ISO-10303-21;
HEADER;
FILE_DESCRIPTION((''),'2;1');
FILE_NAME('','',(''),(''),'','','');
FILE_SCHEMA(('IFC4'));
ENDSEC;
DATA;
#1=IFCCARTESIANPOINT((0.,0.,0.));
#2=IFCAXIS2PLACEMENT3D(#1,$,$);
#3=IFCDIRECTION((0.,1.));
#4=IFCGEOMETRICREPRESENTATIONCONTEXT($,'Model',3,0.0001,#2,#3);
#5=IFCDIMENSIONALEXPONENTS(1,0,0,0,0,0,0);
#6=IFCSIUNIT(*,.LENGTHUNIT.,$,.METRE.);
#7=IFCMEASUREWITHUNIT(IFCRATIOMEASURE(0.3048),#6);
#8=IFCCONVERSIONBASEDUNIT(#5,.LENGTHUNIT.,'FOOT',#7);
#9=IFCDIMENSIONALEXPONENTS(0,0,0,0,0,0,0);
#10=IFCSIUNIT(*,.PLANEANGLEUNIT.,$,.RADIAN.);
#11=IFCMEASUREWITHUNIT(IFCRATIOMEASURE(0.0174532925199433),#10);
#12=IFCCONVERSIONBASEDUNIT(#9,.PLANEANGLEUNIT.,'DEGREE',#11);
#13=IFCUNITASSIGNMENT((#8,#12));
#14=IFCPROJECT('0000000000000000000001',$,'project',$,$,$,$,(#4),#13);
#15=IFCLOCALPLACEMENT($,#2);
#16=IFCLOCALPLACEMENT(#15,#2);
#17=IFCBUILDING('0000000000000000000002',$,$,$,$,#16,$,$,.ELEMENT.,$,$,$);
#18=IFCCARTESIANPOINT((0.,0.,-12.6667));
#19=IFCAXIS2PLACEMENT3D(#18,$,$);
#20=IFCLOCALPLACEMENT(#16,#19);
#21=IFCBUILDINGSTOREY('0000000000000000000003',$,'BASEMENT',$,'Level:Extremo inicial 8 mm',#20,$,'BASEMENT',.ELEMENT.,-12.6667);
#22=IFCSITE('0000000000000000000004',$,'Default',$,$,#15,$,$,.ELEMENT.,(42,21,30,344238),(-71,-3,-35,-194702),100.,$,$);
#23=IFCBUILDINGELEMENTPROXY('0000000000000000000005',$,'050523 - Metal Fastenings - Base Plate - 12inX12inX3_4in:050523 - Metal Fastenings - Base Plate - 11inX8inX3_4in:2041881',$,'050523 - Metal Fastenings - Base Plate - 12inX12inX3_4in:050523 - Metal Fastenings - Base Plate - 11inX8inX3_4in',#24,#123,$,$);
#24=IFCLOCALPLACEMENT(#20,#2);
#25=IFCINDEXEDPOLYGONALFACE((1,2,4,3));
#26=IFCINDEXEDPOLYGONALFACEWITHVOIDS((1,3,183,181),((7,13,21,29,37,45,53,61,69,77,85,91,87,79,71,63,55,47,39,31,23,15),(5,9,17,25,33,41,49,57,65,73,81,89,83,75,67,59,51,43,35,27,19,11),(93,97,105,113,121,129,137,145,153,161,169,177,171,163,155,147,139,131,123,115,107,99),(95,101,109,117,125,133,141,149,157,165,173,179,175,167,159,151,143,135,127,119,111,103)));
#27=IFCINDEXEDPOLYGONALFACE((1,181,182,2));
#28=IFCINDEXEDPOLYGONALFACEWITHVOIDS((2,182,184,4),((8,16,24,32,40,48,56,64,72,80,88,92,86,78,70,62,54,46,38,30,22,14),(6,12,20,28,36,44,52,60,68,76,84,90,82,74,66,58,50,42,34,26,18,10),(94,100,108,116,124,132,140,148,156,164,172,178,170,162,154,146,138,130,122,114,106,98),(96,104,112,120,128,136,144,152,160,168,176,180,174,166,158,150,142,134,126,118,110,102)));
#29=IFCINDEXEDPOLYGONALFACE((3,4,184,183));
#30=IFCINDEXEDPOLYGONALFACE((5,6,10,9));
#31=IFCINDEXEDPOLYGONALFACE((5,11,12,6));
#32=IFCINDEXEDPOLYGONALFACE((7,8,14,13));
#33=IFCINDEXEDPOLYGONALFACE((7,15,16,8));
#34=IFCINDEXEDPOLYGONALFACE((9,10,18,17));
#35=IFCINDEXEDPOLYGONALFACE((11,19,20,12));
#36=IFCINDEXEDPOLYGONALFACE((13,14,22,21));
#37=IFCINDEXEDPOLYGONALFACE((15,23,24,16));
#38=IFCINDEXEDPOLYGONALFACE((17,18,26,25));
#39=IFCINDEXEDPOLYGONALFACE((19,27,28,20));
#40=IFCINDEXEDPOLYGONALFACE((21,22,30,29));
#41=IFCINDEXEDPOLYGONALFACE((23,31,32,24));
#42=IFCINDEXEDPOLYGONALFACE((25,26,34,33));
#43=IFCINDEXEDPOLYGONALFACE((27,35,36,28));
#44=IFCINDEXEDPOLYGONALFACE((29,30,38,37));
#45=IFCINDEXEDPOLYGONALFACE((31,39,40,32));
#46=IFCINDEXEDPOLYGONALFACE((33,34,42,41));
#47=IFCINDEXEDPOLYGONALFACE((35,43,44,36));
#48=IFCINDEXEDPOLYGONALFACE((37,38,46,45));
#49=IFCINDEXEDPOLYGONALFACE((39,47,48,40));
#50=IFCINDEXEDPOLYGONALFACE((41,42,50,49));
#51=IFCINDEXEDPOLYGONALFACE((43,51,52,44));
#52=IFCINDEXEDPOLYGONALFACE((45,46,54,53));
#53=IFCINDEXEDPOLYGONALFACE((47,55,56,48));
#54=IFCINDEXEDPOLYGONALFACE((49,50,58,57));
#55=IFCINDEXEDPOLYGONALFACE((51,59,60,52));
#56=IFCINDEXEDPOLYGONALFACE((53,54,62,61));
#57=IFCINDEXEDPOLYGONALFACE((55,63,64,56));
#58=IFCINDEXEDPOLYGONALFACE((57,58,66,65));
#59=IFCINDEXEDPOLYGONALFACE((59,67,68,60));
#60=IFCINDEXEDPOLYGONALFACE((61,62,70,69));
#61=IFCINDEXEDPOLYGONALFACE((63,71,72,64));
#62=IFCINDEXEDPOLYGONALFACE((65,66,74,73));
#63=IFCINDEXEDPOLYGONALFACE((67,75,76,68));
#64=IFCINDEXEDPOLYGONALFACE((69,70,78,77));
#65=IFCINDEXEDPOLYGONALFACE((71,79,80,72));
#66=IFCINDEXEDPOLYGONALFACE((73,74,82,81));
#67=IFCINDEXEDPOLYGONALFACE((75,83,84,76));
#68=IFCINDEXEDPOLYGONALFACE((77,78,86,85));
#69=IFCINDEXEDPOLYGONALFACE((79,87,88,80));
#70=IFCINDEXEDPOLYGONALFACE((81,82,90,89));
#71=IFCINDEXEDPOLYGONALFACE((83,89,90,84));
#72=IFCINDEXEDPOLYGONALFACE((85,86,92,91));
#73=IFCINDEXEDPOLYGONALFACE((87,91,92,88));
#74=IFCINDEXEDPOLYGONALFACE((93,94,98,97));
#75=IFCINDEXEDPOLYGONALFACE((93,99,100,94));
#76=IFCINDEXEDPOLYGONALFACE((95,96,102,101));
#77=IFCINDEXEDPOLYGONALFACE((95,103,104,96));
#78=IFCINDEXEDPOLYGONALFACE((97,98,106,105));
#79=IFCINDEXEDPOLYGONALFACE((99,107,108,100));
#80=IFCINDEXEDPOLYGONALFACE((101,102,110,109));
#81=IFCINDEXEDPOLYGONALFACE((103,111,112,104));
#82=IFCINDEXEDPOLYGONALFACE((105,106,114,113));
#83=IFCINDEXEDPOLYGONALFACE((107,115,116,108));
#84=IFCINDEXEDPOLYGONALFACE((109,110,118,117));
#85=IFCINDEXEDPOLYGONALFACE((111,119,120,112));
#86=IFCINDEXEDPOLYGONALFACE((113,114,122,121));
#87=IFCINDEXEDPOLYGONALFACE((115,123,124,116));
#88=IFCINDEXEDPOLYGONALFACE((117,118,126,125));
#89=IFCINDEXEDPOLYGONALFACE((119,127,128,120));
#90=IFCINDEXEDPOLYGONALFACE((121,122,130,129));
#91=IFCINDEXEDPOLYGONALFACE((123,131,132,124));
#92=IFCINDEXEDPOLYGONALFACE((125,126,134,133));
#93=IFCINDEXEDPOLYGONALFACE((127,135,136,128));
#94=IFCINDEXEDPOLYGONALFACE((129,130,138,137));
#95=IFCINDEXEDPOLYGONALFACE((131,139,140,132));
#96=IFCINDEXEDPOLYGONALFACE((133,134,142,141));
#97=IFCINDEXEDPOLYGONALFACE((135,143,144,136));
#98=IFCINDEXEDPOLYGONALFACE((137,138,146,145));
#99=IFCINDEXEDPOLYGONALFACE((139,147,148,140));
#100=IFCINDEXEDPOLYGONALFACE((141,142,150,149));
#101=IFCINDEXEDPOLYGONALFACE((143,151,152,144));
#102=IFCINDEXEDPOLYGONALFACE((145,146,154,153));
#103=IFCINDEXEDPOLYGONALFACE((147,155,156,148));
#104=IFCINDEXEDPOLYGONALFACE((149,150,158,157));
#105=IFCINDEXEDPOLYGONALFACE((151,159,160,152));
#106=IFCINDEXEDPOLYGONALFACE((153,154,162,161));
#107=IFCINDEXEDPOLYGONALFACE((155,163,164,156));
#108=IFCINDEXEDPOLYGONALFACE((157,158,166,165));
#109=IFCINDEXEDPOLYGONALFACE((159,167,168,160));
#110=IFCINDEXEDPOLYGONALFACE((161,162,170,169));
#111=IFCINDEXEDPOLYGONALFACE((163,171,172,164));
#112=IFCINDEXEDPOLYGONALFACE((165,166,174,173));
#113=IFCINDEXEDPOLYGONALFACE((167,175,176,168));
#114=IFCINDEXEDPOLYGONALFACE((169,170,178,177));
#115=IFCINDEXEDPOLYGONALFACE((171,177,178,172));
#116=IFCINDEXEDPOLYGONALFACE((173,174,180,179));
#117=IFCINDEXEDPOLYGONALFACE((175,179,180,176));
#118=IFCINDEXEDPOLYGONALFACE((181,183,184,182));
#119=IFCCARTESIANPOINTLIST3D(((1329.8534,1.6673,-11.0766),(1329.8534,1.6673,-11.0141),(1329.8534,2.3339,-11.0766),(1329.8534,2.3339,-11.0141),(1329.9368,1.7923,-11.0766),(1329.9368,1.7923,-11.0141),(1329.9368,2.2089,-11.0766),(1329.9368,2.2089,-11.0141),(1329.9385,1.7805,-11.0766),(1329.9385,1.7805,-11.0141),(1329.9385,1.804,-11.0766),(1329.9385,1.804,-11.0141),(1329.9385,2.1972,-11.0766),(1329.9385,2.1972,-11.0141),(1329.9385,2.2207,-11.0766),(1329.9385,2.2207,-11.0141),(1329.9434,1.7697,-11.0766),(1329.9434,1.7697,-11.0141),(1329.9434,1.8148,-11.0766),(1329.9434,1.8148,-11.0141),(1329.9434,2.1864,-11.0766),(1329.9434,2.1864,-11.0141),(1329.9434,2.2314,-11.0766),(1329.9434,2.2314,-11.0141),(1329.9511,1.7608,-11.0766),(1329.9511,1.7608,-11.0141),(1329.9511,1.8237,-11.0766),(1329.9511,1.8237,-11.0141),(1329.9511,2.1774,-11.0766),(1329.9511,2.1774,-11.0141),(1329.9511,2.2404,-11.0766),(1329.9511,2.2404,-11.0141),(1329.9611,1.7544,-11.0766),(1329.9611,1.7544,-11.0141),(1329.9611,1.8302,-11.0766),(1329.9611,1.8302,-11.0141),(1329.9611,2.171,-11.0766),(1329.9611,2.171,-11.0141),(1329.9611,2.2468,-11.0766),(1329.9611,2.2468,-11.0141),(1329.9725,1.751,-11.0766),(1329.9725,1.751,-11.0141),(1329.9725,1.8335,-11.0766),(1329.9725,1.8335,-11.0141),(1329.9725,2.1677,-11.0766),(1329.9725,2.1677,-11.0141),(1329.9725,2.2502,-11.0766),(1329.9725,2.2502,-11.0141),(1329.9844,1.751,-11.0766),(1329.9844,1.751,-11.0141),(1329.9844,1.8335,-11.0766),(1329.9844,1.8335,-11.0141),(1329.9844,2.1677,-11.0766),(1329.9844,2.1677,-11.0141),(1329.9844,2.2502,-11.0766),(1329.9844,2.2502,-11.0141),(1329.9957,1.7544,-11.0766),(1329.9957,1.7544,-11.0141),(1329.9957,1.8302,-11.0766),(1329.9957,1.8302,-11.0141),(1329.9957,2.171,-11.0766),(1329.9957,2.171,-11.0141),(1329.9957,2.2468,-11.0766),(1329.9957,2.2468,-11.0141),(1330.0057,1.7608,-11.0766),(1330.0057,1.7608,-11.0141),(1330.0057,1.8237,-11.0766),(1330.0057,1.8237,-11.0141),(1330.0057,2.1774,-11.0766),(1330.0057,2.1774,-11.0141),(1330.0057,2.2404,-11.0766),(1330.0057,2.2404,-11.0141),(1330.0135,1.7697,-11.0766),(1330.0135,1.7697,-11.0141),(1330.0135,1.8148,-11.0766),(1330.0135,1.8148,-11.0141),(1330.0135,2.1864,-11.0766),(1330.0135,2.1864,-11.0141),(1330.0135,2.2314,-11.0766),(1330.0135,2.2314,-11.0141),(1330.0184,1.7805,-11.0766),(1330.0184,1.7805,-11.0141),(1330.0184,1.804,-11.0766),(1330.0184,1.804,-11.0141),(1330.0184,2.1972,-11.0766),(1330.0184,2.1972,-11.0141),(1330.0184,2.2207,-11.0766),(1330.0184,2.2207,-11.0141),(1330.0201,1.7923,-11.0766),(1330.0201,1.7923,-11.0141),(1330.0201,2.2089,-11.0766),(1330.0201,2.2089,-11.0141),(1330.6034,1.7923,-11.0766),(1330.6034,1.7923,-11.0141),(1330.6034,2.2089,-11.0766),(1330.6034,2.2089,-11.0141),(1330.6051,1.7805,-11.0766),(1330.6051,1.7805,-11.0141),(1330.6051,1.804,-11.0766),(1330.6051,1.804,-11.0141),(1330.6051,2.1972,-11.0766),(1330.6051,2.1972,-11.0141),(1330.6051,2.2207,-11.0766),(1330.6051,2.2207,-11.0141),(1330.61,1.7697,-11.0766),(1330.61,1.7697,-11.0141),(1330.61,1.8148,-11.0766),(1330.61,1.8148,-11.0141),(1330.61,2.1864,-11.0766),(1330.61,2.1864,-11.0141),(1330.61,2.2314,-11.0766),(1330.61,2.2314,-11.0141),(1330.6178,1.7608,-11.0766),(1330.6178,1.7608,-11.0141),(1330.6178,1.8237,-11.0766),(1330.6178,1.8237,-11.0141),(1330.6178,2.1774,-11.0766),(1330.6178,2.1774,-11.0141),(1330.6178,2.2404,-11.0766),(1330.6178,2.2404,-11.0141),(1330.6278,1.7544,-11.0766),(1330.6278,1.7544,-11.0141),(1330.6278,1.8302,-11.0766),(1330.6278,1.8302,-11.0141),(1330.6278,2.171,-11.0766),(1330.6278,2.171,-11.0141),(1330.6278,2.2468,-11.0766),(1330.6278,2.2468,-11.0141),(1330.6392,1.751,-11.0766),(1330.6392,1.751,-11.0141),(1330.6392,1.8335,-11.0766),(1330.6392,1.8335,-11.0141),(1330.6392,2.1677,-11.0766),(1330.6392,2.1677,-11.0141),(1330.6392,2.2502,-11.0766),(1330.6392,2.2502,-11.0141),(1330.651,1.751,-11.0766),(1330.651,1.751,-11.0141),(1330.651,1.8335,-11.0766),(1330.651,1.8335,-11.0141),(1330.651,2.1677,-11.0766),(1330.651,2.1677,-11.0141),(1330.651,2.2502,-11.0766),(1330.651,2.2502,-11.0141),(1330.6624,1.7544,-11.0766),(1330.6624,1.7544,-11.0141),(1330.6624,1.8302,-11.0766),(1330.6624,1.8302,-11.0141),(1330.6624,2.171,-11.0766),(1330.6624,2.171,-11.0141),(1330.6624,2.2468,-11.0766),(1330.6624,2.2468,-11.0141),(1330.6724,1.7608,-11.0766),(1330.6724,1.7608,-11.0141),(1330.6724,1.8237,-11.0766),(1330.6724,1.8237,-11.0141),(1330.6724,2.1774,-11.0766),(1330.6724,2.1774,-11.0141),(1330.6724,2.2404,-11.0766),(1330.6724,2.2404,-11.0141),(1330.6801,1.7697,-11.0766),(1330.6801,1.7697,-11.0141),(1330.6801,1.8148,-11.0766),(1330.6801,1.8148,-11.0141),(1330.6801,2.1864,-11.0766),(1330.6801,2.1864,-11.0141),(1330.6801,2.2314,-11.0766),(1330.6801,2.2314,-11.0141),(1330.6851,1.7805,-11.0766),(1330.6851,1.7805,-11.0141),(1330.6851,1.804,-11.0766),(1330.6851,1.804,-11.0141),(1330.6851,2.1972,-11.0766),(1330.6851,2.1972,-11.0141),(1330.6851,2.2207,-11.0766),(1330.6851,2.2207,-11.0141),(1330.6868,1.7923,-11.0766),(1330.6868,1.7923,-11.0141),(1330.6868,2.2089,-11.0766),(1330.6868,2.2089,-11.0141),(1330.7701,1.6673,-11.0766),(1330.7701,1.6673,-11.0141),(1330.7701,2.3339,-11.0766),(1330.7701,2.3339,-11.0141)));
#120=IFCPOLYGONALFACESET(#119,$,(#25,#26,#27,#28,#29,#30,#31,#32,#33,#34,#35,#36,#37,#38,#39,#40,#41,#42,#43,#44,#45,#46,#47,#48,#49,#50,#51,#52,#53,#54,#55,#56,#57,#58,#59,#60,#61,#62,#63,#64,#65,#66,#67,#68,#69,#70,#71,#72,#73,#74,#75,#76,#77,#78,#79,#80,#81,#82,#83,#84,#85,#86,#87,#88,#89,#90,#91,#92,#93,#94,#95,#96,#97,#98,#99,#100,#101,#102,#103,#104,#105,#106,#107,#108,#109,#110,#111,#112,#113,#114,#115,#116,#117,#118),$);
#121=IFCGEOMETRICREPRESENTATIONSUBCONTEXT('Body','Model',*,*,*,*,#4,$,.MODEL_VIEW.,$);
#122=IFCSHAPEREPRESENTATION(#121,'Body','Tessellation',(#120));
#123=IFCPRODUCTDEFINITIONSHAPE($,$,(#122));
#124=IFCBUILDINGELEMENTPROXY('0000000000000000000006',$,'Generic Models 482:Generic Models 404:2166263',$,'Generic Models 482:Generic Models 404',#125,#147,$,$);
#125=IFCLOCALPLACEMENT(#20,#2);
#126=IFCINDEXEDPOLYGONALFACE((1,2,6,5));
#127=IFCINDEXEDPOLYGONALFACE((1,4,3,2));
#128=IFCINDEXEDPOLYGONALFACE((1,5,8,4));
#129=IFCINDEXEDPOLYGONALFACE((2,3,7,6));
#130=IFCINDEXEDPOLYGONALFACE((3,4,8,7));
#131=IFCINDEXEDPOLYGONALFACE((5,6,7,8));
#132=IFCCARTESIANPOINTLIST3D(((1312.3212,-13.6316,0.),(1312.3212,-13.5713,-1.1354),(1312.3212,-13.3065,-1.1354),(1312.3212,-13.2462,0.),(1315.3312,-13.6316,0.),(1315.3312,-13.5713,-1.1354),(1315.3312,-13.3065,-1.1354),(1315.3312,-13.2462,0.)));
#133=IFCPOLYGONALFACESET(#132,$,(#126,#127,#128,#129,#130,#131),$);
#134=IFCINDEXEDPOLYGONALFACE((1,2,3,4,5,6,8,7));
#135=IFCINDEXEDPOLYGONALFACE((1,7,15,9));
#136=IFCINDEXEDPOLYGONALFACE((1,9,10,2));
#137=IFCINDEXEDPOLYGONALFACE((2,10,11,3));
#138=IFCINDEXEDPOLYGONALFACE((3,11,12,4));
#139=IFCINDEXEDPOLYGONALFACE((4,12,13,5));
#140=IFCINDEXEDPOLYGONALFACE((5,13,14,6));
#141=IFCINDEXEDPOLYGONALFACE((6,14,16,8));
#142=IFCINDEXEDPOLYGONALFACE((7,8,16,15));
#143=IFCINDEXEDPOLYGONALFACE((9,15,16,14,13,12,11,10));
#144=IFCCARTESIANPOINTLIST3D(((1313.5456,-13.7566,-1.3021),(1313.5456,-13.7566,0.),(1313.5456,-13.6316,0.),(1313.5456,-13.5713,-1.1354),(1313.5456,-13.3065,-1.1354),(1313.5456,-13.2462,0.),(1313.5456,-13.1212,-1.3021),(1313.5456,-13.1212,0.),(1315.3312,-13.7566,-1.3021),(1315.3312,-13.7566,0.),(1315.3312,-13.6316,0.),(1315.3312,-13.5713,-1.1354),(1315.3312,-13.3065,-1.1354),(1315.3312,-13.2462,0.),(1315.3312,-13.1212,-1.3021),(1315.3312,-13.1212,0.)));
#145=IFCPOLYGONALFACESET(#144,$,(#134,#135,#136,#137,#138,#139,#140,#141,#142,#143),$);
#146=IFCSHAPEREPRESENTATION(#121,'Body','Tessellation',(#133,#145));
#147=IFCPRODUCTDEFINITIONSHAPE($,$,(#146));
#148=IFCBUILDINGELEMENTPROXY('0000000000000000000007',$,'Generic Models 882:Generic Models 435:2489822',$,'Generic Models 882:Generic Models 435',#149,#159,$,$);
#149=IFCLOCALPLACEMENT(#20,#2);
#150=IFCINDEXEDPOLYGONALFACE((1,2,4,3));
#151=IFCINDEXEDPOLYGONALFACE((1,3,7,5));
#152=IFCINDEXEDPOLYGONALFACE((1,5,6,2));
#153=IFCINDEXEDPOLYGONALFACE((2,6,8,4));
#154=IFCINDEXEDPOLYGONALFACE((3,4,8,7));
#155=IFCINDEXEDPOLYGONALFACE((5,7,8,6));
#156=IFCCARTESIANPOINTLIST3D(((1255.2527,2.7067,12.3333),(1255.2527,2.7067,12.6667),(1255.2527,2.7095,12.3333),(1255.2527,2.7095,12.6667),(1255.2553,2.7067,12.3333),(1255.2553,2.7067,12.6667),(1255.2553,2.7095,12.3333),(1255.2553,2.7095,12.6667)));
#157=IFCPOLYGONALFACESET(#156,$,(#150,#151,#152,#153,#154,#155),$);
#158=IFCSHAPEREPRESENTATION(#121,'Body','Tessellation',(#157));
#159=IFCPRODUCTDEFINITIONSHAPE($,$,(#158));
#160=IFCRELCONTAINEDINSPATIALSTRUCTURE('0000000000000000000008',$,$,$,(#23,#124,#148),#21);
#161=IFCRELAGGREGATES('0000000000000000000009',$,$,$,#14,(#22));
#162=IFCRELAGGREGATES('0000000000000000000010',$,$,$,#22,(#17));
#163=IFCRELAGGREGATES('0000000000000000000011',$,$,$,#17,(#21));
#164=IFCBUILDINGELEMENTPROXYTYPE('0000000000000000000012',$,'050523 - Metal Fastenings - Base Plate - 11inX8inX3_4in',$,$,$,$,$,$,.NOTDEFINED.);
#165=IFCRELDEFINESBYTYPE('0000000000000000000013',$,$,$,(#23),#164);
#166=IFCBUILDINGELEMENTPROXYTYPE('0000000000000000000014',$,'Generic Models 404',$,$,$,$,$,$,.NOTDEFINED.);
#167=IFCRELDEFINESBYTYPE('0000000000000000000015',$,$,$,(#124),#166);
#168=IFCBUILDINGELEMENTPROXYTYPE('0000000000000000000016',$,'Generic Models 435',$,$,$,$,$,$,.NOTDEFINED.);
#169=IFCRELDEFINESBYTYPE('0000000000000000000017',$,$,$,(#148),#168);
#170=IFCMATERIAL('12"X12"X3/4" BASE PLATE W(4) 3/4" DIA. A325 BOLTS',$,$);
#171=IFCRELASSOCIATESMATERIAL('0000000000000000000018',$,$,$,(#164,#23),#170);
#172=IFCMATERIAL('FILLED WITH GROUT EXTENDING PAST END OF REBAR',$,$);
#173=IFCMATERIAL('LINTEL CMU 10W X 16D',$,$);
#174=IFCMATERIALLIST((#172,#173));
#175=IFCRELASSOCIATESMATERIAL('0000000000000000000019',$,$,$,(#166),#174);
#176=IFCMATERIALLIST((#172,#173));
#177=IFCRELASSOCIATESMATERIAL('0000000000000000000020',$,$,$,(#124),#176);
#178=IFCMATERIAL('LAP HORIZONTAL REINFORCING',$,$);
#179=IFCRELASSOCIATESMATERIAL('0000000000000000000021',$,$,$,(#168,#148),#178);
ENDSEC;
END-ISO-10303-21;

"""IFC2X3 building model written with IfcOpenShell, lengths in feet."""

from ifc_helpers import new_model, entity, si_unit, converted_unit, direction, frame, frame_2d, origin, place, context, subcontext, project, spatial, polyline, circle_curve, parameter, trimmed, segment, composite_curve, rectangle, outline, extrude, source, transform, mapped, material, material_list, type_object, type_shapes, element, save


model = new_model("IFC2X3")

# Units and contexts
model_context = context("Model", 3, precision=0.0001, world=origin(), true_north=direction((0.0, 1.0)))
body_context = subcontext(model_context, "Body", "Model", "MODEL_VIEW")
ifc_project = project(units=[converted_unit("LENGTHUNIT", "FOOT", entity("IfcRatioMeasure", 0.3048), si_unit("LENGTHUNIT", "METRE"), dimensions=[1, 0, 0, 0, 0, 0, 0]), converted_unit("PLANEANGLEUNIT", "DEGREE", entity("IfcRatioMeasure", 0.0174532925199433), si_unit("PLANEANGLEUNIT", "RADIAN"), dimensions=[0, 0, 0, 0, 0, 0, 0])], contexts=[model_context])

# Site, building, storey
site_placement = place(None, origin())
site = spatial("IfcSite", under=ifc_project, at=site_placement, Name="Default", CompositionType="ELEMENT", RefLatitude=(42, 21, 30, 344238), RefLongitude=(-71, -3, -35, -194702), RefElevation=100.0)
building_placement = place(site_placement, origin())
building = spatial("IfcBuilding", under=site, at=building_placement, CompositionType="ELEMENT")
storey_placement = place(building_placement, frame((0.0, 0.0, -12.6667)))
storey = spatial("IfcBuildingStorey", under=building, at=storey_placement, Name="BASEMENT", ObjectType="Level:Extremo inicial 8 mm", LongName="BASEMENT", CompositionType="ELEMENT", Elevation=-12.6667)

# Building element proxies
ifc_material_1 = material(Name="12\"X12\"X3/4\" BASE PLATE W(4) 3/4\" DIA. A325 BOLTS")
building_element_proxy_type_1 = type_object("IfcBuildingElementProxyType", Name="050523 - Metal Fastenings - Base Plate - 11inX8inX3_4in", PredefinedType="NOTDEFINED", material=ifc_material_1)
shared_shape_1 = source(origin(), body_context, "Body", "SweptSolid", [
    extrude(outline(polyline([(-0.4583, -0.3333), (0.4583, -0.3333), (0.4583, 0.3333), (-0.4583, 0.3333), (-0.4583, -0.3333)]), holes=[composite_curve([segment(trimmed(circle_curve(frame_2d((-0.3333, -0.2083), x_axis=(-1.0, 0.0)), 0.0417), [parameter(180.0)], [parameter(0.0)], True, "PARAMETER"), False, "CONTINUOUS"), segment(trimmed(circle_curve(frame_2d((-0.3333, -0.2083), x_axis=(-1.0, 0.0)), 0.0417), [parameter(0.0)], [parameter(180.0)], True, "PARAMETER"), False, "CONTINUOUS")], self_intersect=False), composite_curve([segment(trimmed(circle_curve(frame_2d((0.3333, -0.2083), x_axis=(-1.0, 0.0)), 0.0417), [parameter(180.0)], [parameter(0.0)], True, "PARAMETER"), False, "CONTINUOUS"), segment(trimmed(circle_curve(frame_2d((0.3333, -0.2083), x_axis=(-1.0, 0.0)), 0.0417), [parameter(0.0)], [parameter(180.0)], True, "PARAMETER"), False, "CONTINUOUS")], self_intersect=False), composite_curve([segment(trimmed(circle_curve(frame_2d((-0.3333, 0.2083), x_axis=(-1.0, 0.0)), 0.0417), [parameter(180.0)], [parameter(0.0)], True, "PARAMETER"), False, "CONTINUOUS"), segment(trimmed(circle_curve(frame_2d((-0.3333, 0.2083), x_axis=(-1.0, 0.0)), 0.0417), [parameter(0.0)], [parameter(180.0)], True, "PARAMETER"), False, "CONTINUOUS")], self_intersect=False), composite_curve([segment(trimmed(circle_curve(frame_2d((0.3333, 0.2083), x_axis=(-1.0, 0.0)), 0.0417), [parameter(180.0)], [parameter(0.0)], True, "PARAMETER"), False, "CONTINUOUS"), segment(trimmed(circle_curve(frame_2d((0.3333, 0.2083), x_axis=(-1.0, 0.0)), 0.0417), [parameter(0.0)], [parameter(180.0)], True, "PARAMETER"), False, "CONTINUOUS")], self_intersect=False)]), frame((0.0, 0.0, 0.0), z_axis=(0.0, 0.0, 1.0), x_axis=(-1.0, 0.0, 0.0)), (0.0, 0.0, 1.0), 0.0625),
])
type_shapes(building_element_proxy_type_1, [shared_shape_1])
proxy_1_placement = place(storey_placement, frame((1330.3118, 2.0006, -11.0766)))
element("IfcBuildingElementProxy", 1, at=proxy_1_placement, inside=storey, type_object=building_element_proxy_type_1, material=ifc_material_1, Name="050523 - Metal Fastenings - Base Plate - 12inX12inX3_4in:050523 - Metal Fastenings - Base Plate - 11inX8inX3_4in:2041881", ObjectType="050523 - Metal Fastenings - Base Plate - 12inX12inX3_4in:050523 - Metal Fastenings - Base Plate - 11inX8inX3_4in", context=body_context, shape_type="MappedRepresentation", body=[
    mapped(shared_shape_1, transform((0.0, 0.0, 0.0), scale=1.0)),
])
ifc_material_2 = material(Name="FILLED WITH GROUT EXTENDING PAST END OF REBAR")
ifc_material_3 = material(Name="LINTEL CMU 10W X 16D")
ifc_material_list_1 = material_list([ifc_material_2, ifc_material_3])
ifc_material_list_2 = material_list([ifc_material_2, ifc_material_3])
building_element_proxy_type_2 = type_object("IfcBuildingElementProxyType", Name="Generic Models 404", PredefinedType="NOTDEFINED", material=ifc_material_list_2)
shared_shape_2 = source(origin(), body_context, "Body", "SweptSolid", [
    extrude(outline(polyline([(-0.1324, -0.5677), (0.1324, -0.5677), (0.1927, 0.5677), (-0.1927, 0.5677), (-0.1324, -0.5677)])), frame((0.0, 0.3177, 0.7344), z_axis=(1.0, 0.0, 0.0), x_axis=(0.0, 1.0, 0.0)), (0.0, 0.0, 1.0), 3.01),
    extrude(outline(polyline([(-0.6927, -0.3177), (0.6094, -0.3177), (0.6094, -0.1927), (-0.526, -0.1324), (-0.526, 0.1324), (0.6094, 0.1927), (0.6094, 0.3177), (-0.6927, 0.3177), (-0.6927, -0.3177)])), frame((1.2244, 0.3177, 0.6927), z_axis=(1.0, 0.0, 0.0), x_axis=(0.0, 0.0, 1.0)), (0.0, 0.0, 1.0), 1.7856),
])
type_shapes(building_element_proxy_type_2, [shared_shape_2])
proxy_2_placement = place(storey_placement, frame((1312.3212, -13.7566, -1.3021)))
element("IfcBuildingElementProxy", 2, at=proxy_2_placement, inside=storey, type_object=building_element_proxy_type_2, material=ifc_material_list_1, Name="Generic Models 482:Generic Models 404:2166263", ObjectType="Generic Models 482:Generic Models 404", context=body_context, shape_type="MappedRepresentation", body=[
    mapped(shared_shape_2, transform((0.0, 0.0, 0.0), scale=1.0)),
])
ifc_material_4 = material(Name="LAP HORIZONTAL REINFORCING")
building_element_proxy_type_3 = type_object("IfcBuildingElementProxyType", Name="Generic Models 435", PredefinedType="NOTDEFINED", material=ifc_material_4)
shared_shape_3 = source(origin(), body_context, "Body", "SweptSolid", [
    extrude(rectangle(XDim=0.0028, YDim=0.0026, at=frame_2d((0.0, 0.0), x_axis=(1.0, 0.0))), frame((0.0013, 0.0014, 0.0), z_axis=(0.0, 0.0, 1.0), x_axis=(0.0, 1.0, 0.0)), (0.0, 0.0, 1.0), 0.3333),
])
type_shapes(building_element_proxy_type_3, [shared_shape_3])
proxy_3_placement = place(storey_placement, frame((1255.2527, 2.7067, 12.3333)))
element("IfcBuildingElementProxy", 3, at=proxy_3_placement, inside=storey, type_object=building_element_proxy_type_3, material=ifc_material_4, Name="Generic Models 882:Generic Models 435:2489822", ObjectType="Generic Models 882:Generic Models 435", context=body_context, shape_type="MappedRepresentation", body=[
    mapped(shared_shape_3, transform((0.0, 0.0, 0.0), scale=1.0)),
])

save(model, "model.ifc")
